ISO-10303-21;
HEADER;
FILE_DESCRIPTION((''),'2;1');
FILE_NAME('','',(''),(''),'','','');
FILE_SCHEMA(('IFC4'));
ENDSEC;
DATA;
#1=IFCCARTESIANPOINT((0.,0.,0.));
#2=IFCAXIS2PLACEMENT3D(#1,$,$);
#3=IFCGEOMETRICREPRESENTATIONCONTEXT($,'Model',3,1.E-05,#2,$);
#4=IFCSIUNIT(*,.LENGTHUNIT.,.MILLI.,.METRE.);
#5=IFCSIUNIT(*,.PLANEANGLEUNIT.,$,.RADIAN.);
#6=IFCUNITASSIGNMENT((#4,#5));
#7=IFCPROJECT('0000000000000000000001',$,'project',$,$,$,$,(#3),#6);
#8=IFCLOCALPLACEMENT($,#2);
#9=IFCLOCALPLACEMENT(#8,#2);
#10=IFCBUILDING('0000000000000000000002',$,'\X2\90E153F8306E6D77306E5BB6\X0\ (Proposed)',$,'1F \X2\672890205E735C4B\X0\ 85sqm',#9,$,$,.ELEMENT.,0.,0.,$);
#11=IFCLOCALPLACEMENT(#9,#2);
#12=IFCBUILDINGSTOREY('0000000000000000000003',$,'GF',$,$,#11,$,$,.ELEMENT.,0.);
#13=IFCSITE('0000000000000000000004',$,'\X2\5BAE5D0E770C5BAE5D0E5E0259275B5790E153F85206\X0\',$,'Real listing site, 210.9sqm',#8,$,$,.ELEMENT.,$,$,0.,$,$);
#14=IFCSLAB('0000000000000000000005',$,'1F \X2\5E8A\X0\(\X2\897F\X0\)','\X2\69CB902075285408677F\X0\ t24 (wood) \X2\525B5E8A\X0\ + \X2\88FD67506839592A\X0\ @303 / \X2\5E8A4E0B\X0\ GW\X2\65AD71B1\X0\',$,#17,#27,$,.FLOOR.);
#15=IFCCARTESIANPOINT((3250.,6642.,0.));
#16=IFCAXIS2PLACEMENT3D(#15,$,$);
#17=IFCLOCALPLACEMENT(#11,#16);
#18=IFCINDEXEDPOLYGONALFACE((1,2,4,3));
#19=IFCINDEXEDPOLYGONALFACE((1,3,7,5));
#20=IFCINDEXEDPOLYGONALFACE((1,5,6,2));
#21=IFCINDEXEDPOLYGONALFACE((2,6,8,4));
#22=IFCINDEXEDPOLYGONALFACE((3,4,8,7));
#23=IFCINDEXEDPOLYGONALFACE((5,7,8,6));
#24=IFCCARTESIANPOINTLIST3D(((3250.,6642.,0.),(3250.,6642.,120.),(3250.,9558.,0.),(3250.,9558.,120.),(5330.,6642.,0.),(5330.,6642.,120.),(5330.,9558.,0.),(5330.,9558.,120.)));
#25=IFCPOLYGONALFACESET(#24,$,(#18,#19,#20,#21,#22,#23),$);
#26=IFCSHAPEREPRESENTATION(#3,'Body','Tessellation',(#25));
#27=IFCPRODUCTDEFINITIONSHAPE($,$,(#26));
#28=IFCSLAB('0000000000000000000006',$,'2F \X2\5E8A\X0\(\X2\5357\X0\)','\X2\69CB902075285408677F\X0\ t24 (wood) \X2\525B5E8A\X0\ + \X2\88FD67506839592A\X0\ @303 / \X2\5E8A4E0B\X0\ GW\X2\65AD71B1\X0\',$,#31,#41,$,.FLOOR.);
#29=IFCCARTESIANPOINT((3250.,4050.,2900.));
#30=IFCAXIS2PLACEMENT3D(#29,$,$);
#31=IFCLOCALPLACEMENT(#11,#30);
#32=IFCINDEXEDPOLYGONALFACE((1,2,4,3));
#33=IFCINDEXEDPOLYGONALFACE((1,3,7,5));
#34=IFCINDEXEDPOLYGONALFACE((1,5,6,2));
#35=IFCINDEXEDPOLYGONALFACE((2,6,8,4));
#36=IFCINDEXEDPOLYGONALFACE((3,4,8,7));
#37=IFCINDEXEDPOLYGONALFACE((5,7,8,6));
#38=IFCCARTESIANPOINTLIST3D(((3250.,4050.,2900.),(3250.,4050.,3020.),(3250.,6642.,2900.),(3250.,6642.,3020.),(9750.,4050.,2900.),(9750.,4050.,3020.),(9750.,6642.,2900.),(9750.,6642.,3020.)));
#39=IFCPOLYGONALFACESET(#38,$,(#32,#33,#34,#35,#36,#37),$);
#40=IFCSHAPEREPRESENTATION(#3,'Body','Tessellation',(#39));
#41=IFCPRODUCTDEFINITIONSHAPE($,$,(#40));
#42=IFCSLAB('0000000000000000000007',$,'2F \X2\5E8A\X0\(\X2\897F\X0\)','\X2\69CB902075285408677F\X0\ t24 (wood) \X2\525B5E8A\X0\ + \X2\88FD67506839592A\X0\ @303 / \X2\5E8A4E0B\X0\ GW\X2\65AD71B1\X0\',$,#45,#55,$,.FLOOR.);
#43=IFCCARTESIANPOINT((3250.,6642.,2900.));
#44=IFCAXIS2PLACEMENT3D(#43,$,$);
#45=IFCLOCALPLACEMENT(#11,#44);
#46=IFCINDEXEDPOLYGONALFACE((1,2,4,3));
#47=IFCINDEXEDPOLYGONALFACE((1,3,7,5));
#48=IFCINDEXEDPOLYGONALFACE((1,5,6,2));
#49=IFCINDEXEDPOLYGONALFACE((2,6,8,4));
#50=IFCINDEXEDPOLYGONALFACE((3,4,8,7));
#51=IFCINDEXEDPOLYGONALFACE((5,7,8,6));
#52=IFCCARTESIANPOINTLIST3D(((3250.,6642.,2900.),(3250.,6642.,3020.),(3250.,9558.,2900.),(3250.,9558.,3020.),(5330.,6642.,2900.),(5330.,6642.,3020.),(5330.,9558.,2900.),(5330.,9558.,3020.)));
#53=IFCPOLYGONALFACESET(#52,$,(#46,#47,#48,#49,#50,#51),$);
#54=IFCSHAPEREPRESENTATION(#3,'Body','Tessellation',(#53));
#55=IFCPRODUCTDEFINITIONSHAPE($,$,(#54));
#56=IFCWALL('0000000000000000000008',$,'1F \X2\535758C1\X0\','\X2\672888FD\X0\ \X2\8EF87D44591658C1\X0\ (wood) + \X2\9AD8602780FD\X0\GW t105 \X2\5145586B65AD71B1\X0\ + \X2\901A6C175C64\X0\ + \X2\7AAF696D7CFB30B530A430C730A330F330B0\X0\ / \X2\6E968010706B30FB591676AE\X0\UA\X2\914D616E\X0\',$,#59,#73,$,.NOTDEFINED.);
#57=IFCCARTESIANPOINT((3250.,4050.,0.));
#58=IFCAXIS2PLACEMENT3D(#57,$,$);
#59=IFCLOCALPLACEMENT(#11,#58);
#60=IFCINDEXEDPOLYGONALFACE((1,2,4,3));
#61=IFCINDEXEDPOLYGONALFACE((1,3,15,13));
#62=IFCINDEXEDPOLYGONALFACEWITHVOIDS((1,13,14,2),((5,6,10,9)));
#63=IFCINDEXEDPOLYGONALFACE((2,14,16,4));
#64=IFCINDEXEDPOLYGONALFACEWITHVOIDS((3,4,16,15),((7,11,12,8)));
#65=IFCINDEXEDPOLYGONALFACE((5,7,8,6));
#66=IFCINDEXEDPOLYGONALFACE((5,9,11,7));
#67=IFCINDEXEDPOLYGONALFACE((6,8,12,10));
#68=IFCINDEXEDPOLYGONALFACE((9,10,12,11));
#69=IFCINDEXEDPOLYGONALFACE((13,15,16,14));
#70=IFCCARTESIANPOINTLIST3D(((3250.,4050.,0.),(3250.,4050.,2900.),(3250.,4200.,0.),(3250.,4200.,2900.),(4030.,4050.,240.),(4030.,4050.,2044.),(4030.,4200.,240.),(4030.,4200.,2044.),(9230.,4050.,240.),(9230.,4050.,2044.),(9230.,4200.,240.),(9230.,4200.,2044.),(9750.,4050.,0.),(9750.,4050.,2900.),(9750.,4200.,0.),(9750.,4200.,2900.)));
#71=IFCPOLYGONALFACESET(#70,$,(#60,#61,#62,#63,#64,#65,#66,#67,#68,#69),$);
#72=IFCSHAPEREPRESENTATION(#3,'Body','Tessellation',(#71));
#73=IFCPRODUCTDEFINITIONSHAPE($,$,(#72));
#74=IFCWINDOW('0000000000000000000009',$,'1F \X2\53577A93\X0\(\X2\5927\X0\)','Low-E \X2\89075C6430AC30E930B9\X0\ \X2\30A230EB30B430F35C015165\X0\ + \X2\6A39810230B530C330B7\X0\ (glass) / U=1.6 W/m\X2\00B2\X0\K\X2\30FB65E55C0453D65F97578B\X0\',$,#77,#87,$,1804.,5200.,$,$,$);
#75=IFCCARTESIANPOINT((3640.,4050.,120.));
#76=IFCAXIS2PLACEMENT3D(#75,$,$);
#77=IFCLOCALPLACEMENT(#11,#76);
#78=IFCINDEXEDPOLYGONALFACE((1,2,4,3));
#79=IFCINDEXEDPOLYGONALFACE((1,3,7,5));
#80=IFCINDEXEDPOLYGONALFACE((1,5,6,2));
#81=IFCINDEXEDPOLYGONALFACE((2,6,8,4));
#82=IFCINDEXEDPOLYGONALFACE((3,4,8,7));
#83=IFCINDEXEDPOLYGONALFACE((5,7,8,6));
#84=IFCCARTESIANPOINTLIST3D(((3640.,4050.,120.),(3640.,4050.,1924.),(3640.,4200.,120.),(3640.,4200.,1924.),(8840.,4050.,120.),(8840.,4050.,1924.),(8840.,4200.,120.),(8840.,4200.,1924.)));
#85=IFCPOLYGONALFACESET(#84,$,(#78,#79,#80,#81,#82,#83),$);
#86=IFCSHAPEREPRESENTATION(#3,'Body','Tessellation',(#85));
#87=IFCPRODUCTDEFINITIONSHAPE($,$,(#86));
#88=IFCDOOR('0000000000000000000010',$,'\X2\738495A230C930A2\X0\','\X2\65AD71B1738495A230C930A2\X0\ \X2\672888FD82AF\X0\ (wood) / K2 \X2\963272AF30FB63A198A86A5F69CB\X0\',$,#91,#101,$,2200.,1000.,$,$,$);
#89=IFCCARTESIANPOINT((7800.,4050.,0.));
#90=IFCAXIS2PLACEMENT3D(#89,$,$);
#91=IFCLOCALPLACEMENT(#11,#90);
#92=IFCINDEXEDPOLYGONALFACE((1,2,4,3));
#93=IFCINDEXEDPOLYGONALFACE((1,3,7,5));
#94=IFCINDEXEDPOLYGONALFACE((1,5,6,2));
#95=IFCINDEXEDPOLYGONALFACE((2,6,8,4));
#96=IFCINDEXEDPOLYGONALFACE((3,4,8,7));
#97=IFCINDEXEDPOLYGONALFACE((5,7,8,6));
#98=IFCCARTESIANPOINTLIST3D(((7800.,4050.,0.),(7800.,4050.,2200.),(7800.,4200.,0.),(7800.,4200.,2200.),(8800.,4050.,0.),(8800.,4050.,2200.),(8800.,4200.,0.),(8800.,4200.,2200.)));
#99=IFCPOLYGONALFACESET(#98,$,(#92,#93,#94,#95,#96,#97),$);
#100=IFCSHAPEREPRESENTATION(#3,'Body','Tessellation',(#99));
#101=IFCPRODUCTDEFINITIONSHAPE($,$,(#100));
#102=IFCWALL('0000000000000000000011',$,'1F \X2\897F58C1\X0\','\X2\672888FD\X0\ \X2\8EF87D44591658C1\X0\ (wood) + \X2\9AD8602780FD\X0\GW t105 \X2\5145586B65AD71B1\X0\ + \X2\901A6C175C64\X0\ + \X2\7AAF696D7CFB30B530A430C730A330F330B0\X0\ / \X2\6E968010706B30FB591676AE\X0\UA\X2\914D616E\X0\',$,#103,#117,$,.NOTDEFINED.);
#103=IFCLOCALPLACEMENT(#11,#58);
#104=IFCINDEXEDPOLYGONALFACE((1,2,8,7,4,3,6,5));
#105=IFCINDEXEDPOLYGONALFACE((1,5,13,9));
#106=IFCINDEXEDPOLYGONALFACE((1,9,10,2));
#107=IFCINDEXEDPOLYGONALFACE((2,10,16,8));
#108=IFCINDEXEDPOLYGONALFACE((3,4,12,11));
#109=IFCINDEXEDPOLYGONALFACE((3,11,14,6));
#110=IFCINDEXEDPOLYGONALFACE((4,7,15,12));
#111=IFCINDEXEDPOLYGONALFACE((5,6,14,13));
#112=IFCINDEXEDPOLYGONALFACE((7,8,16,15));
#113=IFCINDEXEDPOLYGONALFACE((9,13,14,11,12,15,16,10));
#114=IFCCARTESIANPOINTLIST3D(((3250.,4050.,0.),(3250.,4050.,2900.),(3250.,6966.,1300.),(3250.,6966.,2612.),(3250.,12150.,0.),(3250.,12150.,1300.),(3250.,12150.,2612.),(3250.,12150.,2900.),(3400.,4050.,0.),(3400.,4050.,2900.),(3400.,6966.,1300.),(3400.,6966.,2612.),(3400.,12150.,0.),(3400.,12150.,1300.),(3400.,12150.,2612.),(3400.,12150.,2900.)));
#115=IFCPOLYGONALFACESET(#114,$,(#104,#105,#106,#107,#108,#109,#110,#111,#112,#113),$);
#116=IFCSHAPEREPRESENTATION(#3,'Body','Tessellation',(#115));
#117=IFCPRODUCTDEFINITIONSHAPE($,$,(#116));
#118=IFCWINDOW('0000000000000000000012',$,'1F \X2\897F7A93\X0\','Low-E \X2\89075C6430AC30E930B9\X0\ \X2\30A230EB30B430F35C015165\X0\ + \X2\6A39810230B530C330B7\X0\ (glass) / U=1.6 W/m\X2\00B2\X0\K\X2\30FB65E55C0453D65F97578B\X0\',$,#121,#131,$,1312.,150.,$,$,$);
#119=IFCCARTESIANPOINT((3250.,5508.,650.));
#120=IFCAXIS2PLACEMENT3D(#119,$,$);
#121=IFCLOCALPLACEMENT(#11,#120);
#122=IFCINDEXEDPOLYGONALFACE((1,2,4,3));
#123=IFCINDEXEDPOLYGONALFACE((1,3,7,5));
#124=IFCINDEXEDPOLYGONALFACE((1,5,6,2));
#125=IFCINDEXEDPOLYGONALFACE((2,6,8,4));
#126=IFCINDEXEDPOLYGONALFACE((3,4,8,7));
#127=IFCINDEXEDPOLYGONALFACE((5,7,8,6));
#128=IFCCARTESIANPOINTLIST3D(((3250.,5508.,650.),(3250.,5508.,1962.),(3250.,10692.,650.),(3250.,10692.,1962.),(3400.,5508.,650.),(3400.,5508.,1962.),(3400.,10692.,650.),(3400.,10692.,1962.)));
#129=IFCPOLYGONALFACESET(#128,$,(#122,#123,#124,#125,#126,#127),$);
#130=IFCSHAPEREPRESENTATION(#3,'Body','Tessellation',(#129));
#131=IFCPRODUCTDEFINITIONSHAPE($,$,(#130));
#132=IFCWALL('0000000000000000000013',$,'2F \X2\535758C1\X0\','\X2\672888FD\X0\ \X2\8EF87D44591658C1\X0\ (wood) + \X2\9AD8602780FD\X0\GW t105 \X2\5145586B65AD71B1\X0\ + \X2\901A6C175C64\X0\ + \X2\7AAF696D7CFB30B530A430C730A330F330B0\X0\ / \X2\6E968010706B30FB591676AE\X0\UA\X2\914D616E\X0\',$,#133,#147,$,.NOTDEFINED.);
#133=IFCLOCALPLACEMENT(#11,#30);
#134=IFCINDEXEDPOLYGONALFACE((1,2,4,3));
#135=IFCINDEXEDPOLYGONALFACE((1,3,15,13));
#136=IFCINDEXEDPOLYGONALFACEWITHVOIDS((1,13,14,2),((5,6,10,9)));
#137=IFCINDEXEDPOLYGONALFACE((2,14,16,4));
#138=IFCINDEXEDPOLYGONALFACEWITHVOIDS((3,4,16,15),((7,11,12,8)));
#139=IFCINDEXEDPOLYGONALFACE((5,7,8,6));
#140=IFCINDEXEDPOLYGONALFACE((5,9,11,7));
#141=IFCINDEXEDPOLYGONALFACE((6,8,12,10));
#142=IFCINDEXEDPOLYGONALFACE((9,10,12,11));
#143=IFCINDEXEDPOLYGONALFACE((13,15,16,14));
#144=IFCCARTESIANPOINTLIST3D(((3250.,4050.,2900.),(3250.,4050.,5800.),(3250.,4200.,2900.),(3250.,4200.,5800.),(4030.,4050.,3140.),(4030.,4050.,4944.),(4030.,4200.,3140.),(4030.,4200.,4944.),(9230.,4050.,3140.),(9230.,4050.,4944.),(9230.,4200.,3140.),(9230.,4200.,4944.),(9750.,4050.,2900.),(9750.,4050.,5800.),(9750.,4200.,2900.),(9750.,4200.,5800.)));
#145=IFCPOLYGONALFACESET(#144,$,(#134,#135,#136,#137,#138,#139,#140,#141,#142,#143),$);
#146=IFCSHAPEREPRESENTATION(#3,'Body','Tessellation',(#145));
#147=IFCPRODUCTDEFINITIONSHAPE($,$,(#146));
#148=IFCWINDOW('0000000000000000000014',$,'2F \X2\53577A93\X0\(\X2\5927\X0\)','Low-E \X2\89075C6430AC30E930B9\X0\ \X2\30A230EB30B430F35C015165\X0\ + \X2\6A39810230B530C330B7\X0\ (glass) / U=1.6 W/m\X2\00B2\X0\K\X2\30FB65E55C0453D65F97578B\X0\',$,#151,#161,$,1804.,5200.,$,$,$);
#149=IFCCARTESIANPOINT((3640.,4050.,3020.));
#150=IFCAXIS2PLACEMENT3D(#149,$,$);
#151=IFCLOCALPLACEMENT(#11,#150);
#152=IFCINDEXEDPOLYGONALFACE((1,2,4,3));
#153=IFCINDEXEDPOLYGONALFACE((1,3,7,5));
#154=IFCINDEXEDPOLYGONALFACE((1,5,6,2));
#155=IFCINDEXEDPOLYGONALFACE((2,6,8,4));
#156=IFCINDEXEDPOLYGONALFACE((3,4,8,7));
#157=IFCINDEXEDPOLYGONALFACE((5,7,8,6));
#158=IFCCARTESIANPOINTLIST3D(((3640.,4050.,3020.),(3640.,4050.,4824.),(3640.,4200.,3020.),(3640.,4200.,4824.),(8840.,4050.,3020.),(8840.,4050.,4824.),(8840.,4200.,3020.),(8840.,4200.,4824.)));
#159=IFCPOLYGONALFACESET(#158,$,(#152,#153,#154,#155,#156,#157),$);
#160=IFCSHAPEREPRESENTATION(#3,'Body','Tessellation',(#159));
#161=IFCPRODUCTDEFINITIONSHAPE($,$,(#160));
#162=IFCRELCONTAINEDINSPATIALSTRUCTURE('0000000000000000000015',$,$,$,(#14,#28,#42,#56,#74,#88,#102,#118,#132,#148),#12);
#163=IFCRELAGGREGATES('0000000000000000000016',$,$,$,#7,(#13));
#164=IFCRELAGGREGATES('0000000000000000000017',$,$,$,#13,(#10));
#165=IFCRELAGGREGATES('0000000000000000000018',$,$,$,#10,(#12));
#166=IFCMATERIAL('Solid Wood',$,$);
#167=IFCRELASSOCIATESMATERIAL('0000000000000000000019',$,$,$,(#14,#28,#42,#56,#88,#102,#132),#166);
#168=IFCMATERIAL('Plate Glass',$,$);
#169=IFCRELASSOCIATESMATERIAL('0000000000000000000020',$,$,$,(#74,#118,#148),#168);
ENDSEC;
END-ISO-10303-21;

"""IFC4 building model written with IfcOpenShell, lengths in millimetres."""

from ifc_helpers import new_model, si_unit, frame, frame_2d, origin, place, context, project, spatial, rectangle, extrude, material, element, fill, save


model = new_model("IFC4")

# Units and contexts
model_context = context("Model", 3, precision=1e-05, world=origin())
ifc_project = project(units=[si_unit("LENGTHUNIT", "METRE", prefix="MILLI"), si_unit("PLANEANGLEUNIT", "RADIAN")], contexts=[model_context])

# Site, building, storey
site_placement = place(None, origin())
site = spatial("IfcSite", under=ifc_project, at=site_placement, Name="宮崎県宮崎市大字郡司分", ObjectType="Real listing site, 210.9sqm", CompositionType="ELEMENT", RefElevation=0.0)
building_placement = place(site_placement, origin())
building = spatial("IfcBuilding", under=site, at=building_placement, Name="郡司の海の家 (Proposed)", ObjectType="1F 木造平屋 85sqm", CompositionType="ELEMENT", ElevationOfRefHeight=0.0, ElevationOfTerrain=0.0)
storey_placement = place(building_placement, origin())
storey = spatial("IfcBuildingStorey", under=building, at=storey_placement, Name="GF", CompositionType="ELEMENT", Elevation=0.0)

# Slabs
ifc_material_1 = material(Name="Solid Wood")
slab_1_placement = place(storey_placement, frame((3250.0, 6642.0, 0.0)))
element("IfcSlab", 1, at=slab_1_placement, inside=storey, material=ifc_material_1, Name="1F 床(西)", Description="構造用合板 t24 (wood) 剛床 + 製材根太 @303 / 床下 GW断熱", PredefinedType="FLOOR", context=model_context, shape_type="SweptSolid", body=[
    extrude(rectangle(XDim=2080.0, YDim=2916.0, at=frame_2d((1040.0, 1458.0))), frame((3250.0, 6642.0, 0.0)), (0.0, 0.0, 1.0), 120.0),
])
slab_2_placement = place(storey_placement, frame((3250.0, 4050.0, 2900.0)))
element("IfcSlab", 2, at=slab_2_placement, inside=storey, material=ifc_material_1, Name="2F 床(南)", Description="構造用合板 t24 (wood) 剛床 + 製材根太 @303 / 床下 GW断熱", PredefinedType="FLOOR", context=model_context, shape_type="SweptSolid", body=[
    extrude(rectangle(XDim=6500.0, YDim=2592.0, at=frame_2d((3250.0, 1296.0))), frame((3250.0, 4050.0, 2900.0)), (0.0, 0.0, 1.0), 120.0),
])
slab_3_placement = place(storey_placement, frame((3250.0, 6642.0, 2900.0)))
element("IfcSlab", 3, at=slab_3_placement, inside=storey, material=ifc_material_1, Name="2F 床(西)", Description="構造用合板 t24 (wood) 剛床 + 製材根太 @303 / 床下 GW断熱", PredefinedType="FLOOR", context=model_context, shape_type="SweptSolid", body=[
    extrude(rectangle(XDim=2080.0, YDim=2916.0, at=frame_2d((1040.0, 1458.0))), frame((3250.0, 6642.0, 2900.0)), (0.0, 0.0, 1.0), 120.0),
])

# Wall, openings, window, door
wall_1_placement = place(storey_placement, frame((3250.0, 4050.0, 0.0)))
wall_1 = element("IfcWall", 4, at=wall_1_placement, inside=storey, material=ifc_material_1, Name="1F 南壁", Description="木製 軸組外壁 (wood) + 高性能GW t105 充填断熱 + 通気層 + 窯業系サイディング / 準耐火・外皮UA配慮", PredefinedType="NOTDEFINED", context=model_context, shape_type="SweptSolid", body=[
    extrude(rectangle(XDim=6500.0, YDim=150.0, at=frame_2d((3250.0, 75.0))), frame((3250.0, 4050.0, 0.0)), (0.0, 0.0, 1.0), 2900.0),
])
opening_1_placement = place(storey_placement, frame((3640.0, 4050.0, 120.0)))
opening_1 = element("IfcOpeningElement", 5, at=opening_1_placement, cuts=wall_1, PredefinedType="NOTDEFINED", context=model_context, shape_type="SweptSolid", body=[
    extrude(rectangle(XDim=5200.0, YDim=150.0, at=frame_2d((2600.0, 75.0))), frame((3640.0, 4050.0, 120.0)), (0.0, 0.0, 1.0), 1804.0),
])
opening_2_placement = place(storey_placement, frame((7800.0, 4050.0, 0.0)))
opening_2 = element("IfcOpeningElement", 6, at=opening_2_placement, cuts=wall_1, PredefinedType="NOTDEFINED", context=model_context, shape_type="SweptSolid", body=[
    extrude(rectangle(XDim=1000.0, YDim=150.0, at=frame_2d((500.0, 75.0))), frame((7800.0, 4050.0, 0.0)), (0.0, 0.0, 1.0), 2200.0),
])
ifc_material_2 = material(Name="Plate Glass")
window_1_placement = place(storey_placement, frame((3640.0, 4050.0, 120.0)))
window_1 = element("IfcWindow", 7, at=window_1_placement, inside=storey, material=ifc_material_2, Name="1F 南窓(大)", Description="Low-E 複層ガラス アルゴン封入 + 樹脂サッシ (glass) / U=1.6 W/m²K・日射取得型", OverallHeight=1804.0, OverallWidth=5200.0, context=model_context, shape_type="SweptSolid", body=[
    extrude(rectangle(XDim=5200.0, YDim=150.0, at=frame_2d((2600.0, 75.0))), frame((3640.0, 4050.0, 120.0)), (0.0, 0.0, 1.0), 1804.0),
])
fill(opening_1, window_1)
door_placement = place(storey_placement, frame((7800.0, 4050.0, 0.0)))
door = element("IfcDoor", 8, at=door_placement, inside=storey, material=ifc_material_1, Name="玄関ドア", Description="断熱玄関ドア 木製芯 (wood) / K2 防犯・採風機構", OverallHeight=2200.0, OverallWidth=1000.0, context=model_context, shape_type="SweptSolid", body=[
    extrude(rectangle(XDim=1000.0, YDim=150.0, at=frame_2d((500.0, 75.0))), frame((7800.0, 4050.0, 0.0)), (0.0, 0.0, 1.0), 2200.0),
])
fill(opening_2, door)

# Walls, openings, windows
wall_2_placement = place(storey_placement, frame((3250.0, 4050.0, 0.0)))
wall_2 = element("IfcWall", 9, at=wall_2_placement, inside=storey, material=ifc_material_1, Name="1F 西壁", Description="木製 軸組外壁 (wood) + 高性能GW t105 充填断熱 + 通気層 + 窯業系サイディング / 準耐火・外皮UA配慮", PredefinedType="NOTDEFINED", context=model_context, shape_type="SweptSolid", body=[
    extrude(rectangle(XDim=150.0, YDim=8100.0, at=frame_2d((75.0, 4050.0))), frame((3250.0, 4050.0, 0.0)), (0.0, 0.0, 1.0), 2900.0),
])
opening_3_placement = place(storey_placement, frame((3250.0, 5508.0, 650.0)))
opening_3 = element("IfcOpeningElement", 10, at=opening_3_placement, cuts=wall_2, PredefinedType="NOTDEFINED", context=model_context, shape_type="SweptSolid", body=[
    extrude(rectangle(XDim=150.0, YDim=5184.0, at=frame_2d((75.0, 2592.0))), frame((3250.0, 5508.0, 650.0)), (0.0, 0.0, 1.0), 1312.0),
])
window_2_placement = place(storey_placement, frame((3250.0, 5508.0, 650.0)))
window_2 = element("IfcWindow", 11, at=window_2_placement, inside=storey, material=ifc_material_2, Name="1F 西窓", Description="Low-E 複層ガラス アルゴン封入 + 樹脂サッシ (glass) / U=1.6 W/m²K・日射取得型", OverallHeight=1312.0, OverallWidth=150.0, context=model_context, shape_type="SweptSolid", body=[
    extrude(rectangle(XDim=150.0, YDim=5184.0, at=frame_2d((75.0, 2592.0))), frame((3250.0, 5508.0, 650.0)), (0.0, 0.0, 1.0), 1312.0),
])
fill(opening_3, window_2)
wall_3_placement = place(storey_placement, frame((3250.0, 4050.0, 2900.0)))
wall_3 = element("IfcWall", 12, at=wall_3_placement, inside=storey, material=ifc_material_1, Name="2F 南壁", Description="木製 軸組外壁 (wood) + 高性能GW t105 充填断熱 + 通気層 + 窯業系サイディング / 準耐火・外皮UA配慮", PredefinedType="NOTDEFINED", context=model_context, shape_type="SweptSolid", body=[
    extrude(rectangle(XDim=6500.0, YDim=150.0, at=frame_2d((3250.0, 75.0))), frame((3250.0, 4050.0, 2900.0)), (0.0, 0.0, 1.0), 2900.0),
])
opening_4_placement = place(storey_placement, frame((3640.0, 4050.0, 3020.0)))
opening_4 = element("IfcOpeningElement", 13, at=opening_4_placement, cuts=wall_3, PredefinedType="NOTDEFINED", context=model_context, shape_type="SweptSolid", body=[
    extrude(rectangle(XDim=5200.0, YDim=150.0, at=frame_2d((2600.0, 75.0))), frame((3640.0, 4050.0, 3020.0)), (0.0, 0.0, 1.0), 1804.0),
])
window_3_placement = place(storey_placement, frame((3640.0, 4050.0, 3020.0)))
window_3 = element("IfcWindow", 14, at=window_3_placement, inside=storey, material=ifc_material_2, Name="2F 南窓(大)", Description="Low-E 複層ガラス アルゴン封入 + 樹脂サッシ (glass) / U=1.6 W/m²K・日射取得型", OverallHeight=1804.0, OverallWidth=5200.0, context=model_context, shape_type="SweptSolid", body=[
    extrude(rectangle(XDim=5200.0, YDim=150.0, at=frame_2d((2600.0, 75.0))), frame((3640.0, 4050.0, 3020.0)), (0.0, 0.0, 1.0), 1804.0),
])
fill(opening_4, window_3)

save(model, "model.ifc")
